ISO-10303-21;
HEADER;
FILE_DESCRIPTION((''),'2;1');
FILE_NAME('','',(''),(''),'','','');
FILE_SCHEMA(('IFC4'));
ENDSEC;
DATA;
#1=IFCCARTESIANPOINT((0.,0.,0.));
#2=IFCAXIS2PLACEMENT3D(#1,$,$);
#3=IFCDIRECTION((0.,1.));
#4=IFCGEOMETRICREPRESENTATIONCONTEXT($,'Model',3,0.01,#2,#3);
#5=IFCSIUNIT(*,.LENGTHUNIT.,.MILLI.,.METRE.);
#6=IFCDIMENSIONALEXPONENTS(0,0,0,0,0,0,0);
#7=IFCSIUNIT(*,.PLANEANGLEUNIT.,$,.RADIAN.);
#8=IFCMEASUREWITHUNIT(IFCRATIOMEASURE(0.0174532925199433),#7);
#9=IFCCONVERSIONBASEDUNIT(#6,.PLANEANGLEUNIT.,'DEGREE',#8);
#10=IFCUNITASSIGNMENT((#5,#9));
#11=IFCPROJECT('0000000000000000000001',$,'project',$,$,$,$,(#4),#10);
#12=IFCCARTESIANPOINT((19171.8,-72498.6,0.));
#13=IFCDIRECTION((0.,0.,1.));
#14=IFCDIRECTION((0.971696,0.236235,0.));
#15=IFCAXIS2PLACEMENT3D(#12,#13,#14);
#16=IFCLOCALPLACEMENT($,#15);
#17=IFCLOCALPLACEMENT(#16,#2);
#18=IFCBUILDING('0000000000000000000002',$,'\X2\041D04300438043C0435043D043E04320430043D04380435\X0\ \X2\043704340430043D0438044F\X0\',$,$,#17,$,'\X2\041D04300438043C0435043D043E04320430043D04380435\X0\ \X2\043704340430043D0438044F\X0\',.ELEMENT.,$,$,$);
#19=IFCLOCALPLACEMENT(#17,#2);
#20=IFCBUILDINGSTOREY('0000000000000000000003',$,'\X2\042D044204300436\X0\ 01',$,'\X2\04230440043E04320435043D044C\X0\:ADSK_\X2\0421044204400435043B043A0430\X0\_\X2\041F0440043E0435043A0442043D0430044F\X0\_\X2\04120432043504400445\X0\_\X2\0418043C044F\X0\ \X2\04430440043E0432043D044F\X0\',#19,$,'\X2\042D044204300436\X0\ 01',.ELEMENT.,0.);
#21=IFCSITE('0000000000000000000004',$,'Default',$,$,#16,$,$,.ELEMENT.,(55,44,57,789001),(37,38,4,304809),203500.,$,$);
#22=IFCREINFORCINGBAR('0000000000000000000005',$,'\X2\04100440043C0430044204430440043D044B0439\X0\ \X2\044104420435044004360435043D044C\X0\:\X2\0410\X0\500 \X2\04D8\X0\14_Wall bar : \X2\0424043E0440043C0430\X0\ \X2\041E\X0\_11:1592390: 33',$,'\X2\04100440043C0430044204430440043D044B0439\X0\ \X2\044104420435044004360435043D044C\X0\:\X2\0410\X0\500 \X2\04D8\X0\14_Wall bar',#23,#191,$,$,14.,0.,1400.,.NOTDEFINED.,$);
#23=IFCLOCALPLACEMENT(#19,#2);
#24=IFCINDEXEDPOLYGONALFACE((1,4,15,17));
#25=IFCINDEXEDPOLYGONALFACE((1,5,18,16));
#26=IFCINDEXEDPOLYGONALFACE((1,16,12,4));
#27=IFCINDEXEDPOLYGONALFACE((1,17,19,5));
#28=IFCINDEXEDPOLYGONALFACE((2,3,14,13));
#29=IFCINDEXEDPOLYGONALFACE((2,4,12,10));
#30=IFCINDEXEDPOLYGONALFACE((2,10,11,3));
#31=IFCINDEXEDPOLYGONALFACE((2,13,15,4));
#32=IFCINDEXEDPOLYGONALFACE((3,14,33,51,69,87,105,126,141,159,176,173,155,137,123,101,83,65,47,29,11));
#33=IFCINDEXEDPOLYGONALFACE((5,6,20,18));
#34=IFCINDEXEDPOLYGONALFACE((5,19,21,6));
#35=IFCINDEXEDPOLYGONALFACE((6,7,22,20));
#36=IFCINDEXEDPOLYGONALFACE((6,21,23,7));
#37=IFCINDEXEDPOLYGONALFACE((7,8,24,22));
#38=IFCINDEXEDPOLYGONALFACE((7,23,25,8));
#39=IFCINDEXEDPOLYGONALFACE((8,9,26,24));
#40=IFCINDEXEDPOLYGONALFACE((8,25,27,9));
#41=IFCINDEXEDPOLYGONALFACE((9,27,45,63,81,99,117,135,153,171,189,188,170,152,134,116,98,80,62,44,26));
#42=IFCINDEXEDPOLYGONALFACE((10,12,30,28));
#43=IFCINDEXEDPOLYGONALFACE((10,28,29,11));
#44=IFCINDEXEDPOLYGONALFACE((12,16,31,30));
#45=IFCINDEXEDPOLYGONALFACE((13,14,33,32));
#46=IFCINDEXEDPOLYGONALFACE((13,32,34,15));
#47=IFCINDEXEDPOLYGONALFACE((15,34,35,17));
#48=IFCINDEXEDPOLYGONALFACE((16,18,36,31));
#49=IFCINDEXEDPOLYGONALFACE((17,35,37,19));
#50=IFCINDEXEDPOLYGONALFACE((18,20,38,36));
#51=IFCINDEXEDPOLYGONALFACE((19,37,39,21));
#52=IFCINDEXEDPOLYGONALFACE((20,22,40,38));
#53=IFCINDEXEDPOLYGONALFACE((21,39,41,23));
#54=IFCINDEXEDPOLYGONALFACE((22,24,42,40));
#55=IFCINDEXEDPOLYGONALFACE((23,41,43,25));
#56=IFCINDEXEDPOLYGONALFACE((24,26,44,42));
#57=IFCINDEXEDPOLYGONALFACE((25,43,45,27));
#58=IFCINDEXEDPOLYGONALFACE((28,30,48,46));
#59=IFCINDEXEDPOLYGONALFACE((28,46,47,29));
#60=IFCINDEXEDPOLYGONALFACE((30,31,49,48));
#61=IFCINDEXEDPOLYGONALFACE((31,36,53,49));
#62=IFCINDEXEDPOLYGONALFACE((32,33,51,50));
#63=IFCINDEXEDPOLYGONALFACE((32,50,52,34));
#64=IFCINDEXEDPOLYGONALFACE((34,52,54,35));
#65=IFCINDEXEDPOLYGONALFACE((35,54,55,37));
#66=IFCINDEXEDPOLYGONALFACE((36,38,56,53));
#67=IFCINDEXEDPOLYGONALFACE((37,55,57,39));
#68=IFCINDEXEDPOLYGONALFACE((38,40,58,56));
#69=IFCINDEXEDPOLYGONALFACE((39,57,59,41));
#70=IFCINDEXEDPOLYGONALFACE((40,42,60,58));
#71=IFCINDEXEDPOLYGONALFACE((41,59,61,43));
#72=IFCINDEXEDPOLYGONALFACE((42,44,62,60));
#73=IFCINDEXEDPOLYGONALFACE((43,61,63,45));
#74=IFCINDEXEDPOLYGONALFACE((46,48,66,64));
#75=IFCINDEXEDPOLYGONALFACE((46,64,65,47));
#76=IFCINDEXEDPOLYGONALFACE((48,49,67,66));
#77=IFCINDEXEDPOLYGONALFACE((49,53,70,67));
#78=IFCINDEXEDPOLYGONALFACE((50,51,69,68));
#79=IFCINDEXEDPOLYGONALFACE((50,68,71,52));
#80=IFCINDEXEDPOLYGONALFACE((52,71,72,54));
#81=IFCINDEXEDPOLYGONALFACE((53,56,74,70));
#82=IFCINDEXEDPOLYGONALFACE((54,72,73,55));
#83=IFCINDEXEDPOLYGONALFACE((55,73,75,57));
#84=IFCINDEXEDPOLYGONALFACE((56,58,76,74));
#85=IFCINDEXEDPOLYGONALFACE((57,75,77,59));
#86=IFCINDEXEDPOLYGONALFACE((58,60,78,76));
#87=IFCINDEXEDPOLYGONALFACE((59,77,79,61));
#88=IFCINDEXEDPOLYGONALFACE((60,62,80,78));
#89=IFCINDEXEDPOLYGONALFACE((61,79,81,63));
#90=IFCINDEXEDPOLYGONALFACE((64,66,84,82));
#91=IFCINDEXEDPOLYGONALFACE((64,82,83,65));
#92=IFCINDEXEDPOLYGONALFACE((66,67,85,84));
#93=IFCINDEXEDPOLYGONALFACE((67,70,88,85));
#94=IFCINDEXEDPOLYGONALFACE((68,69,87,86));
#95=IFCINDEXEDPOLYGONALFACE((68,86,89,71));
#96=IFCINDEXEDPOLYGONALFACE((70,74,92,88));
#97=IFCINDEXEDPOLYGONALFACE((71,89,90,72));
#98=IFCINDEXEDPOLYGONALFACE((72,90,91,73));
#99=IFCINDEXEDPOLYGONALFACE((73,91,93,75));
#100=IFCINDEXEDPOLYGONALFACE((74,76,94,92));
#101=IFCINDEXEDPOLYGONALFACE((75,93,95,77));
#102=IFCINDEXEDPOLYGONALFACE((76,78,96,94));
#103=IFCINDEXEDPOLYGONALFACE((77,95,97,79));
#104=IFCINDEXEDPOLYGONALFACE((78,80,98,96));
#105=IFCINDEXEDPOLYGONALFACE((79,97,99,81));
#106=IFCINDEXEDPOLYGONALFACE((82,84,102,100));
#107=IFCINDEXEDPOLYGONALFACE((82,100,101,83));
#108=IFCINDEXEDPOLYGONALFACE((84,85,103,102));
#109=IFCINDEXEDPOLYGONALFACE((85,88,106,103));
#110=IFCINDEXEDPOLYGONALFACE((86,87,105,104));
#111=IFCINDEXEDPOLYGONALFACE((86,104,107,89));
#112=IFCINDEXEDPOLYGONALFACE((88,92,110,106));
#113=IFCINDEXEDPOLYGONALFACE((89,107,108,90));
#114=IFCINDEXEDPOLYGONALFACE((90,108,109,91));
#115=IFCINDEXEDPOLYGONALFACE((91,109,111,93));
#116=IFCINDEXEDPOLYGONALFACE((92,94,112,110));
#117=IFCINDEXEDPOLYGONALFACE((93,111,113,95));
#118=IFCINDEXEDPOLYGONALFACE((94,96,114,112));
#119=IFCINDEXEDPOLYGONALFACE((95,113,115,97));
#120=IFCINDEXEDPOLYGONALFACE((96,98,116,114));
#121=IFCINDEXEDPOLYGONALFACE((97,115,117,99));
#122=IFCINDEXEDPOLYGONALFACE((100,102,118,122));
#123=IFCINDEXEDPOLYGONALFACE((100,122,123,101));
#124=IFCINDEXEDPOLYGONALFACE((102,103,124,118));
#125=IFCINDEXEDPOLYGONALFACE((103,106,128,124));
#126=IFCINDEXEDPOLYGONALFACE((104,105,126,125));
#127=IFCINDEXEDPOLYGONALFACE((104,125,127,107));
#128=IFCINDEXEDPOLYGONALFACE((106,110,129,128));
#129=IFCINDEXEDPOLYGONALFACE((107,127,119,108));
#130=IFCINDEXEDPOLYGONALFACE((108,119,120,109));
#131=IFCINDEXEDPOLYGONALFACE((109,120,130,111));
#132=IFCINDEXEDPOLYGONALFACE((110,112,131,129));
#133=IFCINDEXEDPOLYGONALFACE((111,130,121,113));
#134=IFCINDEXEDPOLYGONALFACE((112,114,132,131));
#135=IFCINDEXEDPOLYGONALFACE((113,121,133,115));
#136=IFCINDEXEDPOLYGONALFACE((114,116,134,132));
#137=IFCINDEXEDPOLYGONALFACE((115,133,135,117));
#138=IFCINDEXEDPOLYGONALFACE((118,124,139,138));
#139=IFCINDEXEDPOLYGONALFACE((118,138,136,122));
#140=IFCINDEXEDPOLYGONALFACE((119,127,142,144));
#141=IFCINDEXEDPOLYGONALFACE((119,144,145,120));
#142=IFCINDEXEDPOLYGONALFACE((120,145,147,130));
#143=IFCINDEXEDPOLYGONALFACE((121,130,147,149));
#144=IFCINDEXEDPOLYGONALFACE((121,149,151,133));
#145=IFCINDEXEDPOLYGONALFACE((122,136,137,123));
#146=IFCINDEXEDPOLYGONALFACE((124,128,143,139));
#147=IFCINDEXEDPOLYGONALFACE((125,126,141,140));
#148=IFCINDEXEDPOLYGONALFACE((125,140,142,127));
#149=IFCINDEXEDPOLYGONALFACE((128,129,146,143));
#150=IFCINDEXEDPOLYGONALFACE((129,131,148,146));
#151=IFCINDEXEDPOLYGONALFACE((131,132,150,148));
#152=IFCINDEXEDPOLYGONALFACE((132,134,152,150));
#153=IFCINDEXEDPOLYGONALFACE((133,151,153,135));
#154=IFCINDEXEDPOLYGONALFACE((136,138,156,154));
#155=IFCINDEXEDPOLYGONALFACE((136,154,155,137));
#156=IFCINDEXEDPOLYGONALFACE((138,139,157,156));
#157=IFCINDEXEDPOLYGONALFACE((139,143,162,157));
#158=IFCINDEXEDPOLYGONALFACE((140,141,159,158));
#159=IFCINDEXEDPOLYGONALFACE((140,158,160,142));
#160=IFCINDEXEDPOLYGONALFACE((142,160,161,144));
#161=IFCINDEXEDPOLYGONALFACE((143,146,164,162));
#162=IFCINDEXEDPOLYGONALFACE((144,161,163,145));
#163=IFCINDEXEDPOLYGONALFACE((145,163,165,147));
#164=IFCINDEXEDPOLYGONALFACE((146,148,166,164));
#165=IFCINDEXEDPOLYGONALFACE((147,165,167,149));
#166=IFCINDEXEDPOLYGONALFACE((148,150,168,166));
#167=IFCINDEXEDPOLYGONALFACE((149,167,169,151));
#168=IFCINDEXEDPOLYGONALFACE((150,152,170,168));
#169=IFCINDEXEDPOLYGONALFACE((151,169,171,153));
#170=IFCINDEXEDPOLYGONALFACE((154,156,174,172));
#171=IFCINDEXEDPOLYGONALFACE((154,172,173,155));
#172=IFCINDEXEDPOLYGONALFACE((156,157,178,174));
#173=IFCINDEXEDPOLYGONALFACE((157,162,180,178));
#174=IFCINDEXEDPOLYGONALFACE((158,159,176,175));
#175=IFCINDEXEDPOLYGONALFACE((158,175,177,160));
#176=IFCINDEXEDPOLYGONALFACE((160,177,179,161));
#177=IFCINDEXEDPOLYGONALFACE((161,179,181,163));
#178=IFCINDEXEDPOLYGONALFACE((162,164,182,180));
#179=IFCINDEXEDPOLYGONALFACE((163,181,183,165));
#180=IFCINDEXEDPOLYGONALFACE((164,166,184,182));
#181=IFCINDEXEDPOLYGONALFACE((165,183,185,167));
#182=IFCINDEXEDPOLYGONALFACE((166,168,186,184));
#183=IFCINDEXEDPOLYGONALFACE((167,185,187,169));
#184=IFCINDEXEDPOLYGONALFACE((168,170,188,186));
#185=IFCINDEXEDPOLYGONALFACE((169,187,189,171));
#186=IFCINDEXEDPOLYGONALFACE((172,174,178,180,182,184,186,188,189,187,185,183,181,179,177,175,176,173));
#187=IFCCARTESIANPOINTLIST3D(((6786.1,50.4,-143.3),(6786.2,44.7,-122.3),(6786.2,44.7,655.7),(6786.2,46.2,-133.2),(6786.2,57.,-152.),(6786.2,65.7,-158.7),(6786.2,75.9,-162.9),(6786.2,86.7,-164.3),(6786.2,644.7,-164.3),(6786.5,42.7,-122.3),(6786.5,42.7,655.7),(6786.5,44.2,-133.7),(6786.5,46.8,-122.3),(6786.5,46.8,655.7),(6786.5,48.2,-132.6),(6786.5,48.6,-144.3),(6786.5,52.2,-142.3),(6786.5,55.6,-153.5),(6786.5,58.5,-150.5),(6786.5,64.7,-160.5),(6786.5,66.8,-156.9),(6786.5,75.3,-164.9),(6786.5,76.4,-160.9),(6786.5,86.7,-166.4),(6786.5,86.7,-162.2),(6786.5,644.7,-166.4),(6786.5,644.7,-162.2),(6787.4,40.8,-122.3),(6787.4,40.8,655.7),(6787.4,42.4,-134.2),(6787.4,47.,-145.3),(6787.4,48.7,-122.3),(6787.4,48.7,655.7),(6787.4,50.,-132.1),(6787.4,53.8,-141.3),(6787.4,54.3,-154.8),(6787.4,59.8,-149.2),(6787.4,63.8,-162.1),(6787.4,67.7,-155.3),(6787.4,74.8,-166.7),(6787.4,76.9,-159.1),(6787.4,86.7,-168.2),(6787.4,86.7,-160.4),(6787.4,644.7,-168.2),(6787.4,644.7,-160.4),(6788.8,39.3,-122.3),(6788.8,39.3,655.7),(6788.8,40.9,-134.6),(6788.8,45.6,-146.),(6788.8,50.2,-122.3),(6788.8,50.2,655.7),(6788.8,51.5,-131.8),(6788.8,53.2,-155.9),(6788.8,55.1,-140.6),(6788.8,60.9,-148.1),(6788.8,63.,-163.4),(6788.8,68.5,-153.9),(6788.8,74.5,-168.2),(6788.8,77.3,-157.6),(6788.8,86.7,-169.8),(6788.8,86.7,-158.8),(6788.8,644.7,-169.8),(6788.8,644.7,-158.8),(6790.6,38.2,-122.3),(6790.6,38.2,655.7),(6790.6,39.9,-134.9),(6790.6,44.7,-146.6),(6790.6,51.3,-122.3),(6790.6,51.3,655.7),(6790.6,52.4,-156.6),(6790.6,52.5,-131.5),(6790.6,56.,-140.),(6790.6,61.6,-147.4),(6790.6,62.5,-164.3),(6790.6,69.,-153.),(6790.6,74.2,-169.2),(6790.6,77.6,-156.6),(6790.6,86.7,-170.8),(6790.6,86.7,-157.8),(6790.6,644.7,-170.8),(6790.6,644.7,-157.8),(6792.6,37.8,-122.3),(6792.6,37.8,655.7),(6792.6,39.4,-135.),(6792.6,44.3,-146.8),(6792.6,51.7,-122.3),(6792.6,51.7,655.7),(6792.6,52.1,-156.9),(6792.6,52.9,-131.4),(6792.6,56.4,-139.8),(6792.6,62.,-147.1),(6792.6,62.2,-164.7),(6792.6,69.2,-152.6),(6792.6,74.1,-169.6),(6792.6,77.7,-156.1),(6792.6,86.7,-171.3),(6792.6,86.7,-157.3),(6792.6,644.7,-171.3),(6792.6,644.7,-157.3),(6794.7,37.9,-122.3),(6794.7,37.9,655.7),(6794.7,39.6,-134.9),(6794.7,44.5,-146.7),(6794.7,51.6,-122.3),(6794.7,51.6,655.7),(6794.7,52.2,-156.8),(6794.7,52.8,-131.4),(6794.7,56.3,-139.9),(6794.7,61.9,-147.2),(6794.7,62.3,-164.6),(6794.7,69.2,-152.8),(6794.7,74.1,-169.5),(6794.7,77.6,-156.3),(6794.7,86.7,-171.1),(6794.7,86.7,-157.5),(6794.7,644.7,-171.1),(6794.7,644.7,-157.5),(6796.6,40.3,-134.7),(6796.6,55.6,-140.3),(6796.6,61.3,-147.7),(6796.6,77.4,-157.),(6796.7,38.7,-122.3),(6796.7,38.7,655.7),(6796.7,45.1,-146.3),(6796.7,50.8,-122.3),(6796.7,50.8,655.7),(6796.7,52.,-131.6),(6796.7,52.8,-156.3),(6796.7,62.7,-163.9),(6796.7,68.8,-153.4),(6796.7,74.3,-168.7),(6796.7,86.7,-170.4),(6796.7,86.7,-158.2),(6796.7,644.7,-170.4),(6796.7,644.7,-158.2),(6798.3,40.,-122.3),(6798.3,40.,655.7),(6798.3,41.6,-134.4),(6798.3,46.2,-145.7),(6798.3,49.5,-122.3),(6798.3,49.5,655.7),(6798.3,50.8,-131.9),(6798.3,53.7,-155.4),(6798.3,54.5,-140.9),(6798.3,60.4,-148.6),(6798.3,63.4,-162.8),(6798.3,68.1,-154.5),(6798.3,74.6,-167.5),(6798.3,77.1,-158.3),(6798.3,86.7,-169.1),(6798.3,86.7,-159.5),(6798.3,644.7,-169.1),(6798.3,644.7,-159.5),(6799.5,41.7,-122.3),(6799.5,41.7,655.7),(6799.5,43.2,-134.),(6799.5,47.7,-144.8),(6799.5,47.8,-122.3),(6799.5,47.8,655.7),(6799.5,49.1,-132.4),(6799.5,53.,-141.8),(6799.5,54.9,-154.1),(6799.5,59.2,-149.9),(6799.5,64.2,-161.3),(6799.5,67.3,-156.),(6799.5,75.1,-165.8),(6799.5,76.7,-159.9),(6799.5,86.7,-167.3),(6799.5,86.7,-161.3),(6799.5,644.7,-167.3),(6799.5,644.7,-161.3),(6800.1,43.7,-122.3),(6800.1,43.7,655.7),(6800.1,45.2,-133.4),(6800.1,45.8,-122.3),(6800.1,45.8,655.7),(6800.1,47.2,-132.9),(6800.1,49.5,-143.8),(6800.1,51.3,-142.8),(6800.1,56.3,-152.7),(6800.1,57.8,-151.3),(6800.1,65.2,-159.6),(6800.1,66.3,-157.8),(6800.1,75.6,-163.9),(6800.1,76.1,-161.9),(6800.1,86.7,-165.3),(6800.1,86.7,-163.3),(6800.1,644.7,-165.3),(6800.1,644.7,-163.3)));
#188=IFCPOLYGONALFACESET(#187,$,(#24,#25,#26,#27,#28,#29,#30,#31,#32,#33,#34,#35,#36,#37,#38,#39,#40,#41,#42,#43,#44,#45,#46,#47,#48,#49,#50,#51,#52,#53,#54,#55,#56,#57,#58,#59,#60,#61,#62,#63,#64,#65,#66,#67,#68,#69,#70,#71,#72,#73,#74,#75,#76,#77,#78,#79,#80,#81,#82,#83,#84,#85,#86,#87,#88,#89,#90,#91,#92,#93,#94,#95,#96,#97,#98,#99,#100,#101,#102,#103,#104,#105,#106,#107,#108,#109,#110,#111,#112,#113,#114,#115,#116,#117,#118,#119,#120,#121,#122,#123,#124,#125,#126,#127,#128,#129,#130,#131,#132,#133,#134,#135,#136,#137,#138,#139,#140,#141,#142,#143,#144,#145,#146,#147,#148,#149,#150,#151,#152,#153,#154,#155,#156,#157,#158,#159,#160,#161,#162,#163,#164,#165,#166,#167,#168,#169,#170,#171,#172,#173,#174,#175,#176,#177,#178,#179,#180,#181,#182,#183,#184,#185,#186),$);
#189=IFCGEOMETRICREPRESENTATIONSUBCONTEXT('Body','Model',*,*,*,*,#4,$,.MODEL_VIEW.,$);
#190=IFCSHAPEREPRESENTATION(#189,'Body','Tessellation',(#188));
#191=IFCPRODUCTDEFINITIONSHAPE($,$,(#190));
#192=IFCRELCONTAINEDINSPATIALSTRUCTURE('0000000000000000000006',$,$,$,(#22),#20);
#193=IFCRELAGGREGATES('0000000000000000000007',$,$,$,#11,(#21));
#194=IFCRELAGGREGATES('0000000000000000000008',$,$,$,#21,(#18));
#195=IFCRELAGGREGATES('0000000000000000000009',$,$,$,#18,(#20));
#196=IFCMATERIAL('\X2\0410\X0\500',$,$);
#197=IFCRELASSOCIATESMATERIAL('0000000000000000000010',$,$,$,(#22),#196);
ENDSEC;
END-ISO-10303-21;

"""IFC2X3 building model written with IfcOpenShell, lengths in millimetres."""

from ifc_helpers import new_model, entity, si_unit, converted_unit, direction, frame, origin, place, context, subcontext, project, spatial, material, element, save


model = new_model("IFC2X3")

# Units and contexts
model_context = context("Model", 3, precision=0.01, world=origin(), true_north=direction((0.0, 1.0)))
body_context = subcontext(model_context, "Body", "Model", "MODEL_VIEW")
ifc_project = project(units=[si_unit("LENGTHUNIT", "METRE", prefix="MILLI"), converted_unit("PLANEANGLEUNIT", "DEGREE", entity("IfcRatioMeasure", 0.0174532925199433), si_unit("PLANEANGLEUNIT", "RADIAN"), dimensions=[0, 0, 0, 0, 0, 0, 0])], contexts=[model_context])

# Site, building, storey
site_placement = place(None, frame((19171.8, -72498.6, 0.0), z_axis=(0.0, 0.0, 1.0), x_axis=(0.971696, 0.236235, 0.0)))
site = spatial("IfcSite", under=ifc_project, at=site_placement, Name="Default", CompositionType="ELEMENT", RefLatitude=(55, 44, 57, 789001), RefLongitude=(37, 38, 4, 304809), RefElevation=203500.0)
building_placement = place(site_placement, origin())
building = spatial("IfcBuilding", under=site, at=building_placement, Name="Наименование здания", LongName="Наименование здания", CompositionType="ELEMENT")
storey_placement = place(building_placement, origin())
storey = spatial("IfcBuildingStorey", under=building, at=storey_placement, Name="Этаж 01", ObjectType="Уровень:ADSK_Стрелка_Проектная_Вверх_Имя уровня", LongName="Этаж 01", CompositionType="ELEMENT", Elevation=0.0)

# Reinforcing bar
ifc_material = material(Name="А500")
placement = place(storey_placement, origin())
element("IfcReinforcingBar", 1, at=placement, inside=storey, material=ifc_material, Name="Арматурный стержень:А500 Ә14_Wall bar : Форма О_11:1592390: 33", ObjectType="Арматурный стержень:А500 Ә14_Wall bar", BarLength=1400.0, BarRole="NOTDEFINED", CrossSectionArea=0.0, NominalDiameter=14.0, context=body_context, shape_type="AdvancedSweptSolid", body=[
    entity("IfcSweptDiskSolid", entity("IfcCompositeCurve", [entity("IfcCompositeCurveSegment", "CONTINUOUS", True, entity("IfcPolyline", [entity("IfcCartesianPoint", [6793.1, 44.7, 655.7]), entity("IfcCartesianPoint", [6793.1, 44.7, -122.3])])), entity("IfcCompositeCurveSegment", "CONTINUOUS", True, entity("IfcTrimmedCurve", entity("IfcCircle", entity("IfcAxis2Placement3D", entity("IfcCartesianPoint", [6793.1, 86.7, -122.3]), entity("IfcDirection", [1.0, 0.0, 0.0]), entity("IfcDirection", [0.0, 0.0, -1.0])), 42.0), [entity("IfcParameterValue", 270.0)], [entity("IfcParameterValue", 360.0)], True, "PARAMETER")), entity("IfcCompositeCurveSegment", "CONTINUOUS", True, entity("IfcPolyline", [entity("IfcCartesianPoint", [6793.1, 86.7, -164.3]), entity("IfcCartesianPoint", [6793.1, 644.7, -164.3])]))], False), 7.0, None, 0.0, 92.0),
])

save(model, "model.ifc")
